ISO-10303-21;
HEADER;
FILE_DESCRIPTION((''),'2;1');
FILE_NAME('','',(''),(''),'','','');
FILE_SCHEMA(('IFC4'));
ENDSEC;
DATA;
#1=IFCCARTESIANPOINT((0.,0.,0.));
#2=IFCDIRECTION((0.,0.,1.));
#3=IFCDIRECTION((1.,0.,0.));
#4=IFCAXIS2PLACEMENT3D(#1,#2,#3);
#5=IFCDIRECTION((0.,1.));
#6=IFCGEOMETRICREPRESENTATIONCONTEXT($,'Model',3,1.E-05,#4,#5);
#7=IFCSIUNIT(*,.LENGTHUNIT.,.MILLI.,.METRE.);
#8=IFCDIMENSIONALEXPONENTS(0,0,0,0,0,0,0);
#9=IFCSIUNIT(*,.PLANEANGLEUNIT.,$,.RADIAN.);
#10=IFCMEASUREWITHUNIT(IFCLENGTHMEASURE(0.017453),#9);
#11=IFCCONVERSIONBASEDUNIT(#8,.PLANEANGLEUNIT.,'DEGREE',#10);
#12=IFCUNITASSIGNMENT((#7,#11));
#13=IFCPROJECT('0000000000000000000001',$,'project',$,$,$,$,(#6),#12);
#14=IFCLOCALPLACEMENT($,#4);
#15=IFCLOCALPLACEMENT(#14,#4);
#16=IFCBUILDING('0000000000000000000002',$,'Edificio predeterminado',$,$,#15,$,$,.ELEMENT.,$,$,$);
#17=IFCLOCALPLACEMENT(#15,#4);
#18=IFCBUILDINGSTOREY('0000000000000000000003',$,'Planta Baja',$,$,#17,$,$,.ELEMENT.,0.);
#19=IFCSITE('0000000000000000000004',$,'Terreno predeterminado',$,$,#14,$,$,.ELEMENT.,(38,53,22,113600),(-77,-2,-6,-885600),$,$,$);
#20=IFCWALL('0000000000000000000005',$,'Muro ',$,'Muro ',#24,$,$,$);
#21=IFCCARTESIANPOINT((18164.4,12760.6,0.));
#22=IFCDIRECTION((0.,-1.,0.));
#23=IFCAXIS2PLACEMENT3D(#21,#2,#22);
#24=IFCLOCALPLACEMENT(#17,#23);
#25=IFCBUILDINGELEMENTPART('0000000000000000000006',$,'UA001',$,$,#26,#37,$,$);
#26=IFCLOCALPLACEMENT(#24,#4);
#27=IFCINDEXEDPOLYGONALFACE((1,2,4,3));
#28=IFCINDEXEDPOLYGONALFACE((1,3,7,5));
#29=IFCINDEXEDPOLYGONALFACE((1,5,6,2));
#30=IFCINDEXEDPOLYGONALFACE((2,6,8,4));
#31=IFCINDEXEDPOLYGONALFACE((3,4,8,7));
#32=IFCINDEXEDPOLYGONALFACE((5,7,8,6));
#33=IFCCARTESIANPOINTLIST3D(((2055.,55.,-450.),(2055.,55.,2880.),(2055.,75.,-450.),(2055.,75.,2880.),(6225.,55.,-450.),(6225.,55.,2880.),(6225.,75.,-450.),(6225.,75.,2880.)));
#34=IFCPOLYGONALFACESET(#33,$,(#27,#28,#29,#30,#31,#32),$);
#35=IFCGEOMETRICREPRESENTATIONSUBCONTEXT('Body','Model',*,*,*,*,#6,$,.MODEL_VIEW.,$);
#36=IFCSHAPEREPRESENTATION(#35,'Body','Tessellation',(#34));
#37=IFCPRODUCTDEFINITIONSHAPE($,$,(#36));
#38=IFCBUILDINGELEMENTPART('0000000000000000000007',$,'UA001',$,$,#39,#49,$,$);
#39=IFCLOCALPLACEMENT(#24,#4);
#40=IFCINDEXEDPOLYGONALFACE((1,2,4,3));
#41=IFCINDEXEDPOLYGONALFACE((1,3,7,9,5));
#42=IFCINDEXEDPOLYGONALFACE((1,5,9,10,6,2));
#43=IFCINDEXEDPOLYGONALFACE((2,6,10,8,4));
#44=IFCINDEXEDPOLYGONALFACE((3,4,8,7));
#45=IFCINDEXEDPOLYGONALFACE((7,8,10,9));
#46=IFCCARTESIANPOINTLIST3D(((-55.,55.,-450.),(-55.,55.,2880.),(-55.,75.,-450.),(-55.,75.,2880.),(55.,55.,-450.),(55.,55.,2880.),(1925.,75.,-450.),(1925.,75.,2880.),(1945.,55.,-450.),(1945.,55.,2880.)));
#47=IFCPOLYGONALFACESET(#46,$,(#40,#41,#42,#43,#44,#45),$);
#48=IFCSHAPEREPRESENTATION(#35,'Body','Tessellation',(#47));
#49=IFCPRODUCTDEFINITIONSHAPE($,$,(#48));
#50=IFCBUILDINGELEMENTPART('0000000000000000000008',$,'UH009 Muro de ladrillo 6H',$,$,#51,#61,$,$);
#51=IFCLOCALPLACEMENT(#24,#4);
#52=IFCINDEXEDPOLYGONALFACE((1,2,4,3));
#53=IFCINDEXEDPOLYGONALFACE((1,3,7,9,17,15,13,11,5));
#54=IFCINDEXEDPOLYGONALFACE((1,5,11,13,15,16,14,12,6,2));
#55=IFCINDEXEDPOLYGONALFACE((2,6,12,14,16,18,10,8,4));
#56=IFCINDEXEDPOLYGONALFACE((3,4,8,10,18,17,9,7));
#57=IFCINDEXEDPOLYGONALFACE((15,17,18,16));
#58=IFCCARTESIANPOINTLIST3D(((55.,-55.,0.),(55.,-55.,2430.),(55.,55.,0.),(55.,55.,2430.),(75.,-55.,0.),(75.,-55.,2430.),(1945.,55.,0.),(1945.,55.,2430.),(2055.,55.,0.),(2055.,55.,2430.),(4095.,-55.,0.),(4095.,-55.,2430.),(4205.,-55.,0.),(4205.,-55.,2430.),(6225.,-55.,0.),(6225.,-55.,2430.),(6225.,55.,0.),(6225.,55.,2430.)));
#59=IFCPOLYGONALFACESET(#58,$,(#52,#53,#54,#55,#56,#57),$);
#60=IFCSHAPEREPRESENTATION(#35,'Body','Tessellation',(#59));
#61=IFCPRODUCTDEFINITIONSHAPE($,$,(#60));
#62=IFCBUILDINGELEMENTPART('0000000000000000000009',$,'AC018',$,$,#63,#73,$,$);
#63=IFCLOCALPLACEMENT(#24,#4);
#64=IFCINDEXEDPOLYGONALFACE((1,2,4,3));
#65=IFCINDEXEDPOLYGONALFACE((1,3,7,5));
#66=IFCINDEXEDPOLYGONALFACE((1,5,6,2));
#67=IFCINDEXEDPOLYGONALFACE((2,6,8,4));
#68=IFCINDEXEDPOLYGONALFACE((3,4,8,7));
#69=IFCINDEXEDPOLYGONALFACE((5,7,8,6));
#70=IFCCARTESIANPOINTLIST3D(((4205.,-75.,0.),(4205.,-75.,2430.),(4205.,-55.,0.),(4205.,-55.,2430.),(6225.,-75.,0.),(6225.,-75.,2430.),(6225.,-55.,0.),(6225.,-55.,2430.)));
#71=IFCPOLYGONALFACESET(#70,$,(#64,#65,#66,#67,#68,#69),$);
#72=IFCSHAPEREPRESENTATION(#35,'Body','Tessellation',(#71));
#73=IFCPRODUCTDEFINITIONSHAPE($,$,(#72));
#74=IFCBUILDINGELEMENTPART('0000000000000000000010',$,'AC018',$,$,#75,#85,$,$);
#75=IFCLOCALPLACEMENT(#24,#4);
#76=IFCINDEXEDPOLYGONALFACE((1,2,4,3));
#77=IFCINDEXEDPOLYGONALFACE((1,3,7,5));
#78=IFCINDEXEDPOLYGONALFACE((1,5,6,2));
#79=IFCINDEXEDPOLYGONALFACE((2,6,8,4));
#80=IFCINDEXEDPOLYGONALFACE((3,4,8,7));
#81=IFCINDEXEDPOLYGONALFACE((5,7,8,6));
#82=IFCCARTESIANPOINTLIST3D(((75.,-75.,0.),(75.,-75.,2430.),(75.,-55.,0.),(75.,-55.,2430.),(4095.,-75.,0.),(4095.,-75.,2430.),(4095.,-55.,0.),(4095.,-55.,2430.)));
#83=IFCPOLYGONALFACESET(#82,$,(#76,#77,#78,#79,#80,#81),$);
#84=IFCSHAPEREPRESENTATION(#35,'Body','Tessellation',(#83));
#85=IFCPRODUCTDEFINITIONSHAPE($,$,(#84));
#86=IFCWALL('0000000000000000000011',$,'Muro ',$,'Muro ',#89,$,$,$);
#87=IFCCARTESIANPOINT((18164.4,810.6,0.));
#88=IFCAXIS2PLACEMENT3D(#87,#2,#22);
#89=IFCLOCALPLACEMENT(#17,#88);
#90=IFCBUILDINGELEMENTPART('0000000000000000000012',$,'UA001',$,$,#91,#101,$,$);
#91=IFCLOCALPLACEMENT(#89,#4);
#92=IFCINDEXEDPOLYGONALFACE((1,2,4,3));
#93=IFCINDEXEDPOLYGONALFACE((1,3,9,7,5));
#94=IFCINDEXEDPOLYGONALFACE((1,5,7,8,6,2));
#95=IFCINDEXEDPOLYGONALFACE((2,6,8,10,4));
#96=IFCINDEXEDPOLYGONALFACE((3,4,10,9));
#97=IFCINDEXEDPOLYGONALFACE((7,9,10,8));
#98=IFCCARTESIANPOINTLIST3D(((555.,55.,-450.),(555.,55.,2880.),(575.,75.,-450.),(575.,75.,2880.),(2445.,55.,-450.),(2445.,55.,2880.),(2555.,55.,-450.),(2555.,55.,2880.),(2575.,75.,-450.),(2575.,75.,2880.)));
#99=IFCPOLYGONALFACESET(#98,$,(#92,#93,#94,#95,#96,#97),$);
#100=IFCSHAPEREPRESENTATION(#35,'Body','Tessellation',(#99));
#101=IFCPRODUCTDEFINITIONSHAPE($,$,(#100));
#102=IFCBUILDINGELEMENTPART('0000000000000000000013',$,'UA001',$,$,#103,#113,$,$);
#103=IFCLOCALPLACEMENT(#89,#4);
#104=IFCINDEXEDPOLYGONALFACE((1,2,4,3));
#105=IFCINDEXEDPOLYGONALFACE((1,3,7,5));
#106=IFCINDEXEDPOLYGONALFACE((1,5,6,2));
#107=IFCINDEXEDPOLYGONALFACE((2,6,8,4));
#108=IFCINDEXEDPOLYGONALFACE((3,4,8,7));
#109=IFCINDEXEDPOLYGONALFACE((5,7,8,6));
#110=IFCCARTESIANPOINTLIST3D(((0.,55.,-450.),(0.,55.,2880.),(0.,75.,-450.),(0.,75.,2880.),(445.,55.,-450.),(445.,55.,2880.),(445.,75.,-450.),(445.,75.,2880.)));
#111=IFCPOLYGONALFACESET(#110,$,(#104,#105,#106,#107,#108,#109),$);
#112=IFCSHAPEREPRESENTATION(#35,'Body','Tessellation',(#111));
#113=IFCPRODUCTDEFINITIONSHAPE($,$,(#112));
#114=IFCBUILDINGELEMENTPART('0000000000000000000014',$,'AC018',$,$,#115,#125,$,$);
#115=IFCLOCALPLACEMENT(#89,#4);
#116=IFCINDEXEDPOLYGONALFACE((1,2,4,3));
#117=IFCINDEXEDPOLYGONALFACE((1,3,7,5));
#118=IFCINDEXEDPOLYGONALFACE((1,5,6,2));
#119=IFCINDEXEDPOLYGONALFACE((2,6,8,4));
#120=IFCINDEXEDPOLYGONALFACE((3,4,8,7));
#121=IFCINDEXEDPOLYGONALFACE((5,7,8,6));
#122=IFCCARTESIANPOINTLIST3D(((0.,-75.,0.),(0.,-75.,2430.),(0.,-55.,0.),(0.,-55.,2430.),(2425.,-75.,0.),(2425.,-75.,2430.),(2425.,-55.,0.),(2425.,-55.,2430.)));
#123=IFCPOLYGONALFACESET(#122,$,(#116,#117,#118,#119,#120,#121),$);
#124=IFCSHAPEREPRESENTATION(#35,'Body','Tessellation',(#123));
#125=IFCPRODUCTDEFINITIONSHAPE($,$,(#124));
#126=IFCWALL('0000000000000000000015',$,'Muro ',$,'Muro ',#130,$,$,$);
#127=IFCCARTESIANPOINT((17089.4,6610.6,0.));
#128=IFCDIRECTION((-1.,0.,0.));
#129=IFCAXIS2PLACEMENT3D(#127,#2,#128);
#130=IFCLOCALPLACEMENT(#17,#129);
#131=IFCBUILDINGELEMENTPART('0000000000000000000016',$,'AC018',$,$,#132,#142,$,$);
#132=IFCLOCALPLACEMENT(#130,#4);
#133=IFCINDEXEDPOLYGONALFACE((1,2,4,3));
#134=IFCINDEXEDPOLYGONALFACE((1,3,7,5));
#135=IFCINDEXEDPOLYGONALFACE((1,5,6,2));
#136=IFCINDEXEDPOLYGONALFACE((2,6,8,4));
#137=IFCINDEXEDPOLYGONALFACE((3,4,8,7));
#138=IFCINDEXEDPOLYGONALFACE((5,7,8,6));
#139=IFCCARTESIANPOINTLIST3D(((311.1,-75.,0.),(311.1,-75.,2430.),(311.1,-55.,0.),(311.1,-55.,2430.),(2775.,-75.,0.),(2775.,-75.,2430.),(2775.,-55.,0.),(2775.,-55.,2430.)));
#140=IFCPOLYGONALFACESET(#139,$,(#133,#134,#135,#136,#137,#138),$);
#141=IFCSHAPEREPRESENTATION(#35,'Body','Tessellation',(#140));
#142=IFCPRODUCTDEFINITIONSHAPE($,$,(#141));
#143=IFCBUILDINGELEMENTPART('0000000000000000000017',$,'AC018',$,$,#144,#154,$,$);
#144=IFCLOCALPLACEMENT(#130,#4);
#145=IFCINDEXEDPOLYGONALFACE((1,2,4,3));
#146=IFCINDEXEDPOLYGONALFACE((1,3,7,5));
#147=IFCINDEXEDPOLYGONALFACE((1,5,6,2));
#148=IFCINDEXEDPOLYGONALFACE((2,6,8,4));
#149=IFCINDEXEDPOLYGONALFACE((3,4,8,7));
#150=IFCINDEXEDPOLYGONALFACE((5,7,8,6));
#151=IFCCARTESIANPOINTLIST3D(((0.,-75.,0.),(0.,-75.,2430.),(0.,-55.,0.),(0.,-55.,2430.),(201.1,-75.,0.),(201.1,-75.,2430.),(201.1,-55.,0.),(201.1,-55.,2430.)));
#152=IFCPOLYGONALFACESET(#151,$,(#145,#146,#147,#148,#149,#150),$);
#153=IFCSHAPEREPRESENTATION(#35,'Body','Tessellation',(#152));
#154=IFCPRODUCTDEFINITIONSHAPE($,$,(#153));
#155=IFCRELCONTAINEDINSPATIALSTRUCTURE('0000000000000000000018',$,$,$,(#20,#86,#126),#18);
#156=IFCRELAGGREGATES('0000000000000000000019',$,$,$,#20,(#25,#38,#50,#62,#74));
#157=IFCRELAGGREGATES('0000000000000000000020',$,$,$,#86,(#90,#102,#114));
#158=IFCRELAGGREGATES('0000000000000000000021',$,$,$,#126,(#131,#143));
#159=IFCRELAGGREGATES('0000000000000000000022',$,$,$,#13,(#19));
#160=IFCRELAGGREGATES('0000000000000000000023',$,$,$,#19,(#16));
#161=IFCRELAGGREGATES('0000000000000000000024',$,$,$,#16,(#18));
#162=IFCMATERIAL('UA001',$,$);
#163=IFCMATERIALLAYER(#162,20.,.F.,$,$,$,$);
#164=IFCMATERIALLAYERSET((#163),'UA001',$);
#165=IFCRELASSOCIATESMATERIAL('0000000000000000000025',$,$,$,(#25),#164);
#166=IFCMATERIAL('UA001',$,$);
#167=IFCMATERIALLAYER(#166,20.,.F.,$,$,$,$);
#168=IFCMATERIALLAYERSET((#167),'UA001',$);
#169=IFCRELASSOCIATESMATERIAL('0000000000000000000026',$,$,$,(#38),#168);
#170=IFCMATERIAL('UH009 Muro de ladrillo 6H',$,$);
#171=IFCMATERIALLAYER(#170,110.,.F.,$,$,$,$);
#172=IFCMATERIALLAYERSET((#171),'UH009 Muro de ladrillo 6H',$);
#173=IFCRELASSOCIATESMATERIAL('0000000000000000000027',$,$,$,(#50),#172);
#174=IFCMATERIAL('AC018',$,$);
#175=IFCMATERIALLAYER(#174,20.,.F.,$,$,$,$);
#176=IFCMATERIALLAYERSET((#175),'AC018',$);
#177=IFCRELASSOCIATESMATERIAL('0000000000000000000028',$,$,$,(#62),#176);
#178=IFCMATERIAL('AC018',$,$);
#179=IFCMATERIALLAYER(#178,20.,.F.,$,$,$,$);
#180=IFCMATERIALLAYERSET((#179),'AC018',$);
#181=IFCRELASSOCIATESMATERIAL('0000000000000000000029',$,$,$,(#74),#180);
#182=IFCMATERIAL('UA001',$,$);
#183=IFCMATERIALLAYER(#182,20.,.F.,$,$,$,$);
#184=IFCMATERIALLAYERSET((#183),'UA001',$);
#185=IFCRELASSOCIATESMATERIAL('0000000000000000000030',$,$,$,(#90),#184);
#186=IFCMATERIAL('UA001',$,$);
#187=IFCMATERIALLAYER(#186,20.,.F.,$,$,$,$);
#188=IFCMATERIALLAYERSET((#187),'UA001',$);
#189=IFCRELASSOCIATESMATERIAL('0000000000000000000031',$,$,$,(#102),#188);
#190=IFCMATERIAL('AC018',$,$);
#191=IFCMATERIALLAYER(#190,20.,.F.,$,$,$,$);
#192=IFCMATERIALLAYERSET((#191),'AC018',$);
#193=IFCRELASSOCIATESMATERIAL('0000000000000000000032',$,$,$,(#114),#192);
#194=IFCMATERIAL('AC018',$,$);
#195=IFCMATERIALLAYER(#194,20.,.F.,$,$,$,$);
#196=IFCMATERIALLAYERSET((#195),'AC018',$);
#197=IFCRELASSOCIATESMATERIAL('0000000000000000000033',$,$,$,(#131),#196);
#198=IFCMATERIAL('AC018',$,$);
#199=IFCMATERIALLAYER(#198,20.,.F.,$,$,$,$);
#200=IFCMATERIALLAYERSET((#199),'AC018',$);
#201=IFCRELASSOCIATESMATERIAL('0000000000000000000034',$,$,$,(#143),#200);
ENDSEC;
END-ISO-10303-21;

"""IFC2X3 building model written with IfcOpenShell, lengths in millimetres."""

from ifc_helpers import new_model, entity, si_unit, converted_unit, direction, frame, origin_with_axes, place, context, subcontext, project, spatial, polyline, outline, extrude, material, layer, layer_set, layer_usage, element, aggregate, save


model = new_model("IFC2X3")

# Units and contexts
model_context = context("Model", 3, precision=1e-05, world=origin_with_axes(), true_north=direction((0.0, 1.0)))
body_context = subcontext(model_context, "Body", "Model", "MODEL_VIEW")
ifc_project = project(units=[si_unit("LENGTHUNIT", "METRE", prefix="MILLI"), converted_unit("PLANEANGLEUNIT", "DEGREE", entity("IfcLengthMeasure", 0.017453), si_unit("PLANEANGLEUNIT", "RADIAN"), dimensions=[0, 0, 0, 0, 0, 0, 0])], contexts=[model_context])

# Site, building, storey
site_placement = place(None, origin_with_axes())
site = spatial("IfcSite", under=ifc_project, at=site_placement, Name="Terreno predeterminado", CompositionType="ELEMENT", RefLatitude=(38, 53, 22, 113600), RefLongitude=(-77, -2, -6, -885600))
building_placement = place(site_placement, origin_with_axes())
building = spatial("IfcBuilding", under=site, at=building_placement, Name="Edificio predeterminado", CompositionType="ELEMENT")
storey_placement = place(building_placement, origin_with_axes())
storey = spatial("IfcBuildingStorey", under=building, at=storey_placement, Name="Planta Baja", CompositionType="ELEMENT", Elevation=0.0)

# Walls, building element parts
wall_1_placement = place(storey_placement, frame((18164.4, 12760.6, 0.0), z_axis=(0.0, 0.0, 1.0), x_axis=(0.0, -1.0, 0.0)))
wall_1 = element("IfcWall", 1, at=wall_1_placement, inside=storey, Name="Muro ", ObjectType="Muro ")
ifc_material_1 = material(Name="UA001")
ifc_layer_1 = layer(ifc_material_1, 20.0, ventilated=False)
ifc_layer_set_1 = layer_set([ifc_layer_1], Name="UA001")
ifc_layer_usage_1 = layer_usage(ifc_layer_set_1, "AXIS2", "NEGATIVE", -75.0)
building_element_part_1_placement = place(wall_1_placement, origin_with_axes())
building_element_part_1 = element("IfcBuildingElementPart", 2, at=building_element_part_1_placement, material=ifc_layer_usage_1, Name="UA001", context=body_context, shape_type="SweptSolid", body=[
    extrude(outline(polyline([(6225.0, 75.0), (6225.0, 55.0), (2055.0, 55.0), (2055.0, 75.0), (6225.0, 75.0)])), frame((0.0, 0.0, -450.0), z_axis=(0.0, 0.0, 1.0), x_axis=(1.0, 0.0, 0.0)), (0.0, 0.0, 1.0), 3330.0),
])
ifc_material_2 = material(Name="UA001")
ifc_layer_2 = layer(ifc_material_2, 20.0, ventilated=False)
ifc_layer_set_2 = layer_set([ifc_layer_2], Name="UA001")
ifc_layer_usage_2 = layer_usage(ifc_layer_set_2, "AXIS2", "NEGATIVE", -75.0)
building_element_part_2_placement = place(wall_1_placement, origin_with_axes())
building_element_part_2 = element("IfcBuildingElementPart", 3, at=building_element_part_2_placement, material=ifc_layer_usage_2, Name="UA001", context=body_context, shape_type="SweptSolid", body=[
    extrude(outline(polyline([(1925.0, 75.0), (1945.0, 55.0), (55.0, 55.0), (-55.0, 55.0), (-55.0, 75.0), (1925.0, 75.0)])), frame((0.0, 0.0, -450.0), z_axis=(0.0, 0.0, 1.0), x_axis=(1.0, 0.0, 0.0)), (0.0, 0.0, 1.0), 3330.0),
])
ifc_material_3 = material(Name="UH009 Muro de ladrillo 6H")
ifc_layer_3 = layer(ifc_material_3, 110.0, ventilated=False)
ifc_layer_set_3 = layer_set([ifc_layer_3], Name="UH009 Muro de ladrillo 6H")
ifc_layer_usage_3 = layer_usage(ifc_layer_set_3, "AXIS2", "NEGATIVE", -55.0)
building_element_part_3_placement = place(wall_1_placement, origin_with_axes())
building_element_part_3 = element("IfcBuildingElementPart", 4, at=building_element_part_3_placement, material=ifc_layer_usage_3, Name="UH009 Muro de ladrillo 6H", context=body_context, shape_type="SweptSolid", body=[
    extrude(outline(polyline([(6225.0, 55.0), (6225.0, -55.0), (4205.0, -55.0), (4095.0, -55.0), (75.0, -55.0), (55.0, -55.0), (55.0, 55.0), (1945.0, 55.0), (2055.0, 55.0), (6225.0, 55.0)])), origin_with_axes(), (0.0, 0.0, 1.0), 2430.0),
])
ifc_material_4 = material(Name="AC018")
ifc_layer_4 = layer(ifc_material_4, 20.0, ventilated=False)
ifc_layer_set_4 = layer_set([ifc_layer_4], Name="AC018")
ifc_layer_usage_4 = layer_usage(ifc_layer_set_4, "AXIS2", "NEGATIVE", 55.0)
building_element_part_4_placement = place(wall_1_placement, origin_with_axes())
building_element_part_4 = element("IfcBuildingElementPart", 5, at=building_element_part_4_placement, material=ifc_layer_usage_4, Name="AC018", context=body_context, shape_type="SweptSolid", body=[
    extrude(outline(polyline([(6225.0, -55.0), (6225.0, -75.0), (4205.0, -75.0), (4205.0, -55.0), (6225.0, -55.0)])), origin_with_axes(), (0.0, 0.0, 1.0), 2430.0),
])
ifc_material_5 = material(Name="AC018")
ifc_layer_5 = layer(ifc_material_5, 20.0, ventilated=False)
ifc_layer_set_5 = layer_set([ifc_layer_5], Name="AC018")
ifc_layer_usage_5 = layer_usage(ifc_layer_set_5, "AXIS2", "NEGATIVE", 55.0)
building_element_part_5_placement = place(wall_1_placement, origin_with_axes())
building_element_part_5 = element("IfcBuildingElementPart", 6, at=building_element_part_5_placement, material=ifc_layer_usage_5, Name="AC018", context=body_context, shape_type="SweptSolid", body=[
    extrude(outline(polyline([(4095.0, -55.0), (4095.0, -75.0), (75.0, -75.0), (75.0, -55.0), (4095.0, -55.0)])), origin_with_axes(), (0.0, 0.0, 1.0), 2430.0),
])
aggregate(wall_1, [building_element_part_1, building_element_part_2, building_element_part_3, building_element_part_4, building_element_part_5])
wall_2_placement = place(storey_placement, frame((18164.4, 810.6, 0.0), z_axis=(0.0, 0.0, 1.0), x_axis=(0.0, -1.0, 0.0)))
wall_2 = element("IfcWall", 7, at=wall_2_placement, inside=storey, Name="Muro ", ObjectType="Muro ")
ifc_material_6 = material(Name="UA001")
ifc_layer_6 = layer(ifc_material_6, 20.0, ventilated=False)
ifc_layer_set_6 = layer_set([ifc_layer_6], Name="UA001")
ifc_layer_usage_6 = layer_usage(ifc_layer_set_6, "AXIS2", "NEGATIVE", -75.0)
building_element_part_6_placement = place(wall_2_placement, origin_with_axes())
building_element_part_6 = element("IfcBuildingElementPart", 8, at=building_element_part_6_placement, material=ifc_layer_usage_6, Name="UA001", context=body_context, shape_type="SweptSolid", body=[
    extrude(outline(polyline([(2575.0, 75.0), (2555.0, 55.0), (2445.0, 55.0), (555.0, 55.0), (575.0, 75.0), (2575.0, 75.0)])), frame((0.0, 0.0, -450.0), z_axis=(0.0, 0.0, 1.0), x_axis=(1.0, 0.0, 0.0)), (0.0, 0.0, 1.0), 3330.0),
])
ifc_material_7 = material(Name="UA001")
ifc_layer_7 = layer(ifc_material_7, 20.0, ventilated=False)
ifc_layer_set_7 = layer_set([ifc_layer_7], Name="UA001")
ifc_layer_usage_7 = layer_usage(ifc_layer_set_7, "AXIS2", "NEGATIVE", -75.0)
building_element_part_7_placement = place(wall_2_placement, origin_with_axes())
building_element_part_7 = element("IfcBuildingElementPart", 9, at=building_element_part_7_placement, material=ifc_layer_usage_7, Name="UA001", context=body_context, shape_type="SweptSolid", body=[
    extrude(outline(polyline([(445.0, 75.0), (445.0, 55.0), (0.0, 55.0), (0.0, 75.0), (445.0, 75.0)])), frame((0.0, 0.0, -450.0), z_axis=(0.0, 0.0, 1.0), x_axis=(1.0, 0.0, 0.0)), (0.0, 0.0, 1.0), 3330.0),
])
ifc_material_8 = material(Name="AC018")
ifc_layer_8 = layer(ifc_material_8, 20.0, ventilated=False)
ifc_layer_set_8 = layer_set([ifc_layer_8], Name="AC018")
ifc_layer_usage_8 = layer_usage(ifc_layer_set_8, "AXIS2", "NEGATIVE", 55.0)
building_element_part_8_placement = place(wall_2_placement, origin_with_axes())
building_element_part_8 = element("IfcBuildingElementPart", 10, at=building_element_part_8_placement, material=ifc_layer_usage_8, Name="AC018", context=body_context, shape_type="SweptSolid", body=[
    extrude(outline(polyline([(2425.0, -55.0), (2425.0, -75.0), (0.0, -75.0), (0.0, -55.0), (2425.0, -55.0)])), origin_with_axes(), (0.0, 0.0, 1.0), 2430.0),
])
aggregate(wall_2, [building_element_part_6, building_element_part_7, building_element_part_8])
wall_3_placement = place(storey_placement, frame((17089.4, 6610.6, 0.0), z_axis=(0.0, 0.0, 1.0), x_axis=(-1.0, 0.0, 0.0)))
wall_3 = element("IfcWall", 11, at=wall_3_placement, inside=storey, Name="Muro ", ObjectType="Muro ")
ifc_material_9 = material(Name="AC018")
ifc_layer_9 = layer(ifc_material_9, 20.0, ventilated=False)
ifc_layer_set_9 = layer_set([ifc_layer_9], Name="AC018")
ifc_layer_usage_9 = layer_usage(ifc_layer_set_9, "AXIS2", "NEGATIVE", 55.0)
building_element_part_9_placement = place(wall_3_placement, origin_with_axes())
building_element_part_9 = element("IfcBuildingElementPart", 12, at=building_element_part_9_placement, material=ifc_layer_usage_9, Name="AC018", context=body_context, shape_type="SweptSolid", body=[
    extrude(outline(polyline([(2775.0, -55.0), (2775.0, -75.0), (311.1, -75.0), (311.1, -55.0), (2775.0, -55.0)])), origin_with_axes(), (0.0, 0.0, 1.0), 2430.0),
])
ifc_material_10 = material(Name="AC018")
ifc_layer_10 = layer(ifc_material_10, 20.0, ventilated=False)
ifc_layer_set_10 = layer_set([ifc_layer_10], Name="AC018")
ifc_layer_usage_10 = layer_usage(ifc_layer_set_10, "AXIS2", "NEGATIVE", 55.0)
building_element_part_10_placement = place(wall_3_placement, origin_with_axes())
building_element_part_10 = element("IfcBuildingElementPart", 13, at=building_element_part_10_placement, material=ifc_layer_usage_10, Name="AC018", context=body_context, shape_type="SweptSolid", body=[
    extrude(outline(polyline([(201.1, -55.0), (201.1, -75.0), (0.0, -75.0), (0.0, -55.0), (201.1, -55.0)])), origin_with_axes(), (0.0, 0.0, 1.0), 2430.0),
])
aggregate(wall_3, [building_element_part_9, building_element_part_10])

save(model, "model.ifc")
